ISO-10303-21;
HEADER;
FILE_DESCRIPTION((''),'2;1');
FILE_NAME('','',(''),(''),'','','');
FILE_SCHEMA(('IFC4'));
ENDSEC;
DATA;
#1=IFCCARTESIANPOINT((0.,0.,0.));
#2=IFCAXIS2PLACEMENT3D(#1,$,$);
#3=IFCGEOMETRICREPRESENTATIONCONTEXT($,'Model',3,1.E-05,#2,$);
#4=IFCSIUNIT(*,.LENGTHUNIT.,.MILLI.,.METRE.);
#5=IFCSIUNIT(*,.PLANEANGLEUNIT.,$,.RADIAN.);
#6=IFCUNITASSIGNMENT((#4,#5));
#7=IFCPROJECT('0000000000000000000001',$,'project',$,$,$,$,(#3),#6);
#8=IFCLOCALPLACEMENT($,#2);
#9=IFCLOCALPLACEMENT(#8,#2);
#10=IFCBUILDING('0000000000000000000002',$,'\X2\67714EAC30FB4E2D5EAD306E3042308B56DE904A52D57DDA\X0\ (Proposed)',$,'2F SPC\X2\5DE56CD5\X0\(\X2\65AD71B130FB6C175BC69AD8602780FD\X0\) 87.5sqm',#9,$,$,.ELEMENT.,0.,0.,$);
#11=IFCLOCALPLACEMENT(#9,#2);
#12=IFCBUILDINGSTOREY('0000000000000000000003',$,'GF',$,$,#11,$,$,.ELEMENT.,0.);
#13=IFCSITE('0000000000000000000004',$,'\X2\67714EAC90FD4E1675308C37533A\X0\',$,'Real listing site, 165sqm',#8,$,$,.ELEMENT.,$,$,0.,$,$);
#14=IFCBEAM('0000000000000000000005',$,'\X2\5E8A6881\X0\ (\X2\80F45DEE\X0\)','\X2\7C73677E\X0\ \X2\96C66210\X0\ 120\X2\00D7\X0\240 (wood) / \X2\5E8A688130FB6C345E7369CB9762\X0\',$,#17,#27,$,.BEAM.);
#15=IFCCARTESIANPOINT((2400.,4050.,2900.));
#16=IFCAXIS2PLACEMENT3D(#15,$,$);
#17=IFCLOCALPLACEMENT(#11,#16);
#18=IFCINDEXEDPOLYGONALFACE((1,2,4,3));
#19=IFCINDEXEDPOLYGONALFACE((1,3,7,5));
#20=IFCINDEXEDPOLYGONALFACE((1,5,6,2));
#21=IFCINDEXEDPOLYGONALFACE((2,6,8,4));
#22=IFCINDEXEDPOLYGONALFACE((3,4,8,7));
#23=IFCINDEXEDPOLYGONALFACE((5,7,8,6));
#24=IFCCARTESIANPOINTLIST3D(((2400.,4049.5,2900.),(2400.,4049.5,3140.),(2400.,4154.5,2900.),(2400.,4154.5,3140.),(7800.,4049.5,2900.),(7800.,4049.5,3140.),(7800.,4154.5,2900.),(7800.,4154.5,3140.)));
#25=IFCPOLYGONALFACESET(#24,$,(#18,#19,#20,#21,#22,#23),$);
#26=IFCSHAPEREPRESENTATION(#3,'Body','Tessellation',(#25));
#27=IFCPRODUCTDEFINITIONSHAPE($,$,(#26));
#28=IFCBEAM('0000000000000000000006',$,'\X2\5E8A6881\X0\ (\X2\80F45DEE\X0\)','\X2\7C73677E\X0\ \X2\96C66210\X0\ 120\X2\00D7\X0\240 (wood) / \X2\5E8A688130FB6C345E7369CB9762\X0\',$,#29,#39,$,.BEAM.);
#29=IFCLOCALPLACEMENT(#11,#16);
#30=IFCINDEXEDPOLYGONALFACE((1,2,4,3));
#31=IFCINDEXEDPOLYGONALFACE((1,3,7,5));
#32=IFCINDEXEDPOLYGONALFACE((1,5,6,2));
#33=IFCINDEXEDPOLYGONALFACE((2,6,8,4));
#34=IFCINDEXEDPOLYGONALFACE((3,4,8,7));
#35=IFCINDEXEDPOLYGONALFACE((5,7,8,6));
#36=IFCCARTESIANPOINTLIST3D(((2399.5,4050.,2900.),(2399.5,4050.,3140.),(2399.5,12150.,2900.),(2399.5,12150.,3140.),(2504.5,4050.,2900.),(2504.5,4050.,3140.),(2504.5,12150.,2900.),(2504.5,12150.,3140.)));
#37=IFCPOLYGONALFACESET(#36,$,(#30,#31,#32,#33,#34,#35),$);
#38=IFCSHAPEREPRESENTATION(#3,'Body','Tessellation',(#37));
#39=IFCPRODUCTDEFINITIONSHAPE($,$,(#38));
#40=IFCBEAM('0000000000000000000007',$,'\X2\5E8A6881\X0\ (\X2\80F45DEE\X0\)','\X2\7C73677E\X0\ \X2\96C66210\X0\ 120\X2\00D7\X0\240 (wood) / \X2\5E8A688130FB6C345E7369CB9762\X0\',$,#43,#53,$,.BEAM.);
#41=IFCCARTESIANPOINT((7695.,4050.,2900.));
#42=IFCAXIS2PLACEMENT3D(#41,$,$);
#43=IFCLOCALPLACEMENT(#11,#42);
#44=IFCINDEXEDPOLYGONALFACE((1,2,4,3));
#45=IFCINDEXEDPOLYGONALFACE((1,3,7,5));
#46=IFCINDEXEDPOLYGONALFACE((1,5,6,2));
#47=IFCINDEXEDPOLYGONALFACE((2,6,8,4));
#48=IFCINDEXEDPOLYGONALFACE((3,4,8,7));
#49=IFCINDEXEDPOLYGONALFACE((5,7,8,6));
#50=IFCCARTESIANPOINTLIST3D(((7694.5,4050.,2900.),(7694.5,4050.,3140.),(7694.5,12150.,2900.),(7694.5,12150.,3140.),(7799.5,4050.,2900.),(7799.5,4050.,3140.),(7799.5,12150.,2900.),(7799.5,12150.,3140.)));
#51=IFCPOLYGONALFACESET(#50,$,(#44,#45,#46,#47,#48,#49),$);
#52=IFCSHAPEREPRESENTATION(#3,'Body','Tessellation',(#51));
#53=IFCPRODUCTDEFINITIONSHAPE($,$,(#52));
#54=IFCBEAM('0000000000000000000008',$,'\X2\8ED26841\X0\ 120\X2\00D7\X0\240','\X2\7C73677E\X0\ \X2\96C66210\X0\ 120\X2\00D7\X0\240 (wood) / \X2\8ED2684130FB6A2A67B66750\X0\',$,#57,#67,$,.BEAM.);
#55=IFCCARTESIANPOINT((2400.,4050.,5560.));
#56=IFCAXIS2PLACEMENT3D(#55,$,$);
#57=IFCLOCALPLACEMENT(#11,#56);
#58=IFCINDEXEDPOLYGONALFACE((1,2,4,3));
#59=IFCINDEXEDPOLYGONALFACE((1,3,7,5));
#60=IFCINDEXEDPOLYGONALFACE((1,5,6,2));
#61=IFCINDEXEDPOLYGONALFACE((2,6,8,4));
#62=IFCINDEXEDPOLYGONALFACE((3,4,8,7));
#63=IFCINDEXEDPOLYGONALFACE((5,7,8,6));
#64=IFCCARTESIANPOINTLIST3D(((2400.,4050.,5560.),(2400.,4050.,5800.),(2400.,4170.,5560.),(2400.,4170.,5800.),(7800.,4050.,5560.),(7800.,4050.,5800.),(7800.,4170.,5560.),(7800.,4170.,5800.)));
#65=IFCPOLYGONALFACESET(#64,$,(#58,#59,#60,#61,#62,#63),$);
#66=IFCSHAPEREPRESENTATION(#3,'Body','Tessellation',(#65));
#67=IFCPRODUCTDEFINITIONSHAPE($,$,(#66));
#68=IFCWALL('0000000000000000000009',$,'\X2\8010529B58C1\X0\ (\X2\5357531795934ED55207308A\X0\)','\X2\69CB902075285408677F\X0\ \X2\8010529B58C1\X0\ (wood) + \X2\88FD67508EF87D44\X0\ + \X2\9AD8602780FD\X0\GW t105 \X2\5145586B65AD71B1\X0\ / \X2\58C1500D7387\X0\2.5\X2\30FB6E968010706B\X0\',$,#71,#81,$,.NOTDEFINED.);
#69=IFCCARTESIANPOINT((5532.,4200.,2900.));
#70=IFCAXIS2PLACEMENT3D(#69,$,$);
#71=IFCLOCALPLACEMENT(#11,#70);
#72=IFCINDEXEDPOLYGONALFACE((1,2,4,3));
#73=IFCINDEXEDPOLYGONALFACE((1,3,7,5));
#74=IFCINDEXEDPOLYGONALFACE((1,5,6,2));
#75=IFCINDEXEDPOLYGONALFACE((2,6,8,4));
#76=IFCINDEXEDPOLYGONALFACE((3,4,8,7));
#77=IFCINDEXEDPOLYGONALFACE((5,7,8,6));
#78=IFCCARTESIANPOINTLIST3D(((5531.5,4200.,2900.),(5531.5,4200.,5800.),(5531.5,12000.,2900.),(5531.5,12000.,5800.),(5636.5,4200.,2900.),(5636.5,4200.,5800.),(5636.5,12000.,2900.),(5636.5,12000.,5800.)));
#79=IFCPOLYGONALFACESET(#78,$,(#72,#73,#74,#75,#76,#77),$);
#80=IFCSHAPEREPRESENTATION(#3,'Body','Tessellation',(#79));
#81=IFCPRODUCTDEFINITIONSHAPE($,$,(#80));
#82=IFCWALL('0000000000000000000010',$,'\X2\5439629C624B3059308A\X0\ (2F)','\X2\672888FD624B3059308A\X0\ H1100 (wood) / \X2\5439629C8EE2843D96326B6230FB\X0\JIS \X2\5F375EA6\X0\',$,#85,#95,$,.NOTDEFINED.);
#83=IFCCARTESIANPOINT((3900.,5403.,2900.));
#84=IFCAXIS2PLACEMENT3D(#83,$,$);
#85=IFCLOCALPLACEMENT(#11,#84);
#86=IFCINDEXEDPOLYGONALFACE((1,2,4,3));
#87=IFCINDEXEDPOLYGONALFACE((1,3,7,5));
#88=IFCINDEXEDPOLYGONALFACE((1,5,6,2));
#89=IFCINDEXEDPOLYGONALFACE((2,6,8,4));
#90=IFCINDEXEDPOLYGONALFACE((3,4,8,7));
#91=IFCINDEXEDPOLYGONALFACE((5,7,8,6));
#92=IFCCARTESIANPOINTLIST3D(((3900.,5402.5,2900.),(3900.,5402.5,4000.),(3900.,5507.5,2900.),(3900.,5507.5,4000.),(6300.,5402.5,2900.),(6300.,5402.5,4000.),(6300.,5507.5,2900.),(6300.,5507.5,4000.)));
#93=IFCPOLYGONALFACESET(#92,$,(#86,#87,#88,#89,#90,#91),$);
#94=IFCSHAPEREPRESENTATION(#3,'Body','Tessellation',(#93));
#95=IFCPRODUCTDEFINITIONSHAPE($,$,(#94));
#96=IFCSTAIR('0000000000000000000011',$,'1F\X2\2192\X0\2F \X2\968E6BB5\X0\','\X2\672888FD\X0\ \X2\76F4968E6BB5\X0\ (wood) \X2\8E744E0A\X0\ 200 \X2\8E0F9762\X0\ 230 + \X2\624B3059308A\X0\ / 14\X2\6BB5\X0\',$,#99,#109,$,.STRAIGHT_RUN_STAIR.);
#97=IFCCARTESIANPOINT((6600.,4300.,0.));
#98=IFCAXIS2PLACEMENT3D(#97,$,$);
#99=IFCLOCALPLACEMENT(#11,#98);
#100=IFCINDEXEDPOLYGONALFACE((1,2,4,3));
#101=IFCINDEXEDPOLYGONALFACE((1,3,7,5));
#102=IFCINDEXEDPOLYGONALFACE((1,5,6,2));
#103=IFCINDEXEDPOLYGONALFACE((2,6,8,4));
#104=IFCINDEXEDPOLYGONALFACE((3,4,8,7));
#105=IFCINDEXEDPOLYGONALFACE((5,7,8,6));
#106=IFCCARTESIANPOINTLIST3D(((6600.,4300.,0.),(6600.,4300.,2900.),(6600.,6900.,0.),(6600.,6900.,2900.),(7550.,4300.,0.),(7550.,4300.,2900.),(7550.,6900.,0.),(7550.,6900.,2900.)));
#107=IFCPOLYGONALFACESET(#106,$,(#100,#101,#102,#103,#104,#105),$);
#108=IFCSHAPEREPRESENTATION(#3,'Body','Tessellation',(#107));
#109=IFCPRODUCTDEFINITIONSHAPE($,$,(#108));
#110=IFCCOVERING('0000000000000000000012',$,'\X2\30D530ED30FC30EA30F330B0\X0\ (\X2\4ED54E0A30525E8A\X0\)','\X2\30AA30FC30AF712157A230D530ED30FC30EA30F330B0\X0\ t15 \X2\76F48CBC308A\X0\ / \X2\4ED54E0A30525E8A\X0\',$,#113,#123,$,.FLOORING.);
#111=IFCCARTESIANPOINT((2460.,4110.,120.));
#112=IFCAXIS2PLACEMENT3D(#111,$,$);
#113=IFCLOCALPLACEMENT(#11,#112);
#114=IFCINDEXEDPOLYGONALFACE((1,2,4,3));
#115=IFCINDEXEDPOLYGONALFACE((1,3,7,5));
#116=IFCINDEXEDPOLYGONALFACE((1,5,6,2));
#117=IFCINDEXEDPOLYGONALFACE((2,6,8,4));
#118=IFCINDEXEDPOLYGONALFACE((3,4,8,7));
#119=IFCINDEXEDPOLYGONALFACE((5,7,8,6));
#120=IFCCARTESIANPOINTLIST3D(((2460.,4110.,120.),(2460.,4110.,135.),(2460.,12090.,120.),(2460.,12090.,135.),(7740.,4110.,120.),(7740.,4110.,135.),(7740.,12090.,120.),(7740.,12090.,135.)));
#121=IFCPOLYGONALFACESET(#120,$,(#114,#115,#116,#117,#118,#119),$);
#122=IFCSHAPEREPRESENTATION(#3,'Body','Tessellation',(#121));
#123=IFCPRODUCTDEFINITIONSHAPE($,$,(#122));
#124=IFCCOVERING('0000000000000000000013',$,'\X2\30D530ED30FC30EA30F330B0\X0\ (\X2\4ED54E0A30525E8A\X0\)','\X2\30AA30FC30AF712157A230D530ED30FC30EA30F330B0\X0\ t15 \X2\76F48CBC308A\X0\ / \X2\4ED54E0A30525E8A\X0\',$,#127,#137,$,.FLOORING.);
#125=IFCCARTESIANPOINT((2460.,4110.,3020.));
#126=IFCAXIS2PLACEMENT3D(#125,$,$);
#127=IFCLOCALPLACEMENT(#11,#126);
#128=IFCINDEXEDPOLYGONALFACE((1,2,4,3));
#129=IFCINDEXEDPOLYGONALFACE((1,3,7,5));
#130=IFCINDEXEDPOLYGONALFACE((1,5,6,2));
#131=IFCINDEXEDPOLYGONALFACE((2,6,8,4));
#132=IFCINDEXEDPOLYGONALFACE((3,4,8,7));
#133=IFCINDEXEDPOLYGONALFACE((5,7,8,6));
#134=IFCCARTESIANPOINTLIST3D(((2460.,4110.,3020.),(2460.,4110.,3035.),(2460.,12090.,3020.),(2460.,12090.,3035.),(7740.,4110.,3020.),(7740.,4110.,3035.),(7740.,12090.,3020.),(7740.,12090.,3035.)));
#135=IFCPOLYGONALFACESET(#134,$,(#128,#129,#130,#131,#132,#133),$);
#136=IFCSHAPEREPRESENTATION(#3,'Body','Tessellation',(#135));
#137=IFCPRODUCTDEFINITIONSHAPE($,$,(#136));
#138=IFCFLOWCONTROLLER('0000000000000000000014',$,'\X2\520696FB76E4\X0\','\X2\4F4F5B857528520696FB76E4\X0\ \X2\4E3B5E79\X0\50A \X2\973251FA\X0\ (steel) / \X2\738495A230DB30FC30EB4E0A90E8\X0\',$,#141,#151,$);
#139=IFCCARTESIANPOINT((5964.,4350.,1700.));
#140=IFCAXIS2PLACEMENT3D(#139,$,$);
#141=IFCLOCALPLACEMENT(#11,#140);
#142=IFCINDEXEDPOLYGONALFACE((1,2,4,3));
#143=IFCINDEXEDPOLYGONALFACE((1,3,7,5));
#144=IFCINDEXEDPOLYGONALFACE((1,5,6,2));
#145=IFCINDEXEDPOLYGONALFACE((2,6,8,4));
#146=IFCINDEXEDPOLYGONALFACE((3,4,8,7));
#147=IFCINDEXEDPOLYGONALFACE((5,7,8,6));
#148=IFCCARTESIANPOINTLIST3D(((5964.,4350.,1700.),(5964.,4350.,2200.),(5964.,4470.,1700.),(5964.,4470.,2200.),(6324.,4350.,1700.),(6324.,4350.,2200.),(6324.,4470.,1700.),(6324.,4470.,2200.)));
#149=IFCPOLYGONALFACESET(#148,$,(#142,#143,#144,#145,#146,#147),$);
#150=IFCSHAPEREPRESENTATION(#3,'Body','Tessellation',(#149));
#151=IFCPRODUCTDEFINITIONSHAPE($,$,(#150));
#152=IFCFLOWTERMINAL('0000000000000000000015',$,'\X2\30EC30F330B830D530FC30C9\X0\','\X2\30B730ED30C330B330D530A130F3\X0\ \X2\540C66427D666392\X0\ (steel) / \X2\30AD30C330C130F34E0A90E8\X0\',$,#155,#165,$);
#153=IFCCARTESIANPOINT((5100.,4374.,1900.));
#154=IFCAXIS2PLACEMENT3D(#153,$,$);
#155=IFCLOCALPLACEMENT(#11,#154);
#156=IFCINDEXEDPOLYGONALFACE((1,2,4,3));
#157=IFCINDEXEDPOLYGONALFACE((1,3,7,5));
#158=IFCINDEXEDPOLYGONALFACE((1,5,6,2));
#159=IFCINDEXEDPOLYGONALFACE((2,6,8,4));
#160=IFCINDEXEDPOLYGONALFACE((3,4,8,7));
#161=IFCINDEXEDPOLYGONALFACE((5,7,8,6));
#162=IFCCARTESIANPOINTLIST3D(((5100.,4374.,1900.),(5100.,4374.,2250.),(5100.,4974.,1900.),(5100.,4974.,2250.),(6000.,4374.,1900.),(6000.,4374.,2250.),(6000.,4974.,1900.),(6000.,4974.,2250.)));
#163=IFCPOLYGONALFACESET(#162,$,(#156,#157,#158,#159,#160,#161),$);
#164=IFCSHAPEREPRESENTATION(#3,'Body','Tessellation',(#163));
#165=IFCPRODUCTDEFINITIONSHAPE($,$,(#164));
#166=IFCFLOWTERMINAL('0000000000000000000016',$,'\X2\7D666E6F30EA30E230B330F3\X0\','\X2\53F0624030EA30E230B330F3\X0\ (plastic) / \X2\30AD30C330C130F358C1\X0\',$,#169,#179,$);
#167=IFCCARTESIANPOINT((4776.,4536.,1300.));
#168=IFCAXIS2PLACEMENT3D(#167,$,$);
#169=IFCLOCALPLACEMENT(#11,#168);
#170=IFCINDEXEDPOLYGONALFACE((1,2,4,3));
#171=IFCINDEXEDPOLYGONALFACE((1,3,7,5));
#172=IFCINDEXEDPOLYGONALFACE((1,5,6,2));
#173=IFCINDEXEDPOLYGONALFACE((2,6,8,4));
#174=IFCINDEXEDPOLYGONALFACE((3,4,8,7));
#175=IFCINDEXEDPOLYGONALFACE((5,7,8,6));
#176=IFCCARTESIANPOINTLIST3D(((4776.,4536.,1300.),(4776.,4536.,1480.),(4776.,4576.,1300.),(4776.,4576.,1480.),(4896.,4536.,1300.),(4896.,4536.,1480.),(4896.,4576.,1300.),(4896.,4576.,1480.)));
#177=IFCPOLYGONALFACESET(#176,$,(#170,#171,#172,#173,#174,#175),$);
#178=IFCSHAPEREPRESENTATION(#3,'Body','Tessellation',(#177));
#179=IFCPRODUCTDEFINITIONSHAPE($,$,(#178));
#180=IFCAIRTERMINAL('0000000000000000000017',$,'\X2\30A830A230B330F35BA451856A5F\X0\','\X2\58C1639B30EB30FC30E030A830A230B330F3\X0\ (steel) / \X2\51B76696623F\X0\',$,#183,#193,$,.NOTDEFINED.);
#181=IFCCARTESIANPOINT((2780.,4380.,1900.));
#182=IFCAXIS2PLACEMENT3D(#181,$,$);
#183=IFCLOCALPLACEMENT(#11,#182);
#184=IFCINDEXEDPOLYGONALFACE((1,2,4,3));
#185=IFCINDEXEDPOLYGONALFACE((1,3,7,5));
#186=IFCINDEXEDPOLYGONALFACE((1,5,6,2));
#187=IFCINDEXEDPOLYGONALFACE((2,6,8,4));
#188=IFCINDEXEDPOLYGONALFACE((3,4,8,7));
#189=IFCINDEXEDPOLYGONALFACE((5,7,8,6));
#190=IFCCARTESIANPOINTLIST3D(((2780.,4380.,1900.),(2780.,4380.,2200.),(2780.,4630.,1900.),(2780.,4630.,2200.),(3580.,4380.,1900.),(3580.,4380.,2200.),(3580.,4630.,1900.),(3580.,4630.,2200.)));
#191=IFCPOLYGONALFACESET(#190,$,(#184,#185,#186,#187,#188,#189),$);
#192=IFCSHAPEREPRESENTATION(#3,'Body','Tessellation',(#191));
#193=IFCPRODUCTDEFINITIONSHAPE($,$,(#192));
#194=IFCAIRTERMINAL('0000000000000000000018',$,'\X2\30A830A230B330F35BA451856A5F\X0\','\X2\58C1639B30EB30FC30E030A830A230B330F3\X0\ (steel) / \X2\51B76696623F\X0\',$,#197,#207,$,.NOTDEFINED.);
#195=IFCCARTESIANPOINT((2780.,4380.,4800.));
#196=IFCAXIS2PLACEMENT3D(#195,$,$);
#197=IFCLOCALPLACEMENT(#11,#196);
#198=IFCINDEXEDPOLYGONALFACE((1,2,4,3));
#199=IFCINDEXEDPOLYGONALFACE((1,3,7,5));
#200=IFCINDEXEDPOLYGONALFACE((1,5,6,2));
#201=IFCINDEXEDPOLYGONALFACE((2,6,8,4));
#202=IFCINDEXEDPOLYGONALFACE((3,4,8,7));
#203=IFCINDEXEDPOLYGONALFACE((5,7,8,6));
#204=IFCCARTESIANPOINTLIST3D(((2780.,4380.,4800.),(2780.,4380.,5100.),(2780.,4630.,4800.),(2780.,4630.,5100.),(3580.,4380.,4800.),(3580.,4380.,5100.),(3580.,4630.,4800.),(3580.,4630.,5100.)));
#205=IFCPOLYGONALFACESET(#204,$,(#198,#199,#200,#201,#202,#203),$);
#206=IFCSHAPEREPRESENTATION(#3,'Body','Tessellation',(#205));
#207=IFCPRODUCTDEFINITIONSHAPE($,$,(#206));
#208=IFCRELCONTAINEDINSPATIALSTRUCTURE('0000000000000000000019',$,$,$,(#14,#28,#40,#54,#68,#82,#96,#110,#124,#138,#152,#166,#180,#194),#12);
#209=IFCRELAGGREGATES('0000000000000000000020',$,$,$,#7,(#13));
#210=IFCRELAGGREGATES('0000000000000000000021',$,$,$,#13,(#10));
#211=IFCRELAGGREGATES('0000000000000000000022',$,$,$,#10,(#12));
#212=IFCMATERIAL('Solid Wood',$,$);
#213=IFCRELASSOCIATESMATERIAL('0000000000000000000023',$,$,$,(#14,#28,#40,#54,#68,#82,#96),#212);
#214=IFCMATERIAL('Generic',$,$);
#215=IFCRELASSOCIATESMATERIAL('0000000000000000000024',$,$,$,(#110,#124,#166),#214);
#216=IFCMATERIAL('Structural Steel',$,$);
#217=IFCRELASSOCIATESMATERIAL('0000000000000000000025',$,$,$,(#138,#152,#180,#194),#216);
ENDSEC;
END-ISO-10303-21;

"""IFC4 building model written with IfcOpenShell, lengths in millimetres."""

from ifc_helpers import new_model, si_unit, frame, frame_2d, origin, place, context, project, spatial, rectangle, extrude, material, element, save


model = new_model("IFC4")

# Units and contexts
model_context = context("Model", 3, precision=1e-05, world=origin())
ifc_project = project(units=[si_unit("LENGTHUNIT", "METRE", prefix="MILLI"), si_unit("PLANEANGLEUNIT", "RADIAN")], contexts=[model_context])

# Site, building, storey
site_placement = place(None, origin())
site = spatial("IfcSite", under=ifc_project, at=site_placement, Name="東京都世田谷区", ObjectType="Real listing site, 165sqm", CompositionType="ELEMENT", RefElevation=0.0)
building_placement = place(site_placement, origin())
building = spatial("IfcBuilding", under=site, at=building_placement, Name="東京・中庭のある回遊動線 (Proposed)", ObjectType="2F SPC工法(断熱・気密高性能) 87.5sqm", CompositionType="ELEMENT", ElevationOfRefHeight=0.0, ElevationOfTerrain=0.0)
storey_placement = place(building_placement, origin())
storey = spatial("IfcBuildingStorey", under=building, at=storey_placement, Name="GF", CompositionType="ELEMENT", Elevation=0.0)

# Shared definitions
ifc_material_1 = material(Name="Solid Wood")

# Beams
beam_1_placement = place(storey_placement, frame((2400.0, 4050.0, 2900.0)))
element("IfcBeam", 1, at=beam_1_placement, inside=storey, material=ifc_material_1, Name="床梁 (胴差)", Description="米松 集成 120×240 (wood) / 床梁・水平構面", PredefinedType="BEAM", context=model_context, shape_type="SweptSolid", body=[
    extrude(rectangle(XDim=5400.0, YDim=105.0, at=frame_2d((2700.0, 52.0))), frame((2400.0, 4050.0, 2900.0)), (0.0, 0.0, 1.0), 240.0),
])
beam_2_placement = place(storey_placement, frame((2400.0, 4050.0, 2900.0)))
element("IfcBeam", 2, at=beam_2_placement, inside=storey, material=ifc_material_1, Name="床梁 (胴差)", Description="米松 集成 120×240 (wood) / 床梁・水平構面", PredefinedType="BEAM", context=model_context, shape_type="SweptSolid", body=[
    extrude(rectangle(XDim=105.0, YDim=8100.0, at=frame_2d((52.0, 4050.0))), frame((2400.0, 4050.0, 2900.0)), (0.0, 0.0, 1.0), 240.0),
])
beam_3_placement = place(storey_placement, frame((7695.0, 4050.0, 2900.0)))
element("IfcBeam", 3, at=beam_3_placement, inside=storey, material=ifc_material_1, Name="床梁 (胴差)", Description="米松 集成 120×240 (wood) / 床梁・水平構面", PredefinedType="BEAM", context=model_context, shape_type="SweptSolid", body=[
    extrude(rectangle(XDim=105.0, YDim=8100.0, at=frame_2d((52.0, 4050.0))), frame((7695.0, 4050.0, 2900.0)), (0.0, 0.0, 1.0), 240.0),
])
beam_4_placement = place(storey_placement, frame((2400.0, 4050.0, 5560.0)))
element("IfcBeam", 4, at=beam_4_placement, inside=storey, material=ifc_material_1, Name="軒桁 120×240", Description="米松 集成 120×240 (wood) / 軒桁・横架材", PredefinedType="BEAM", context=model_context, shape_type="SweptSolid", body=[
    extrude(rectangle(XDim=5400.0, YDim=120.0, at=frame_2d((2700.0, 60.0))), frame((2400.0, 4050.0, 5560.0)), (0.0, 0.0, 1.0), 240.0),
])

# Walls
wall_1_placement = place(storey_placement, frame((5532.0, 4200.0, 2900.0)))
element("IfcWall", 5, at=wall_1_placement, inside=storey, material=ifc_material_1, Name="耐力壁 (南北間仕切り)", Description="構造用合板 耐力壁 (wood) + 製材軸組 + 高性能GW t105 充填断熱 / 壁倍率2.5・準耐火", PredefinedType="NOTDEFINED", context=model_context, shape_type="SweptSolid", body=[
    extrude(rectangle(XDim=105.0, YDim=7800.0, at=frame_2d((52.0, 3900.0))), frame((5532.0, 4200.0, 2900.0)), (0.0, 0.0, 1.0), 2900.0),
])
wall_2_placement = place(storey_placement, frame((3900.0, 5403.0, 2900.0)))
element("IfcWall", 6, at=wall_2_placement, inside=storey, material=ifc_material_1, Name="吹抜手すり (2F)", Description="木製手すり H1100 (wood) / 吹抜転落防止・JIS 強度", PredefinedType="NOTDEFINED", context=model_context, shape_type="SweptSolid", body=[
    extrude(rectangle(XDim=2400.0, YDim=105.0, at=frame_2d((1200.0, 52.0))), frame((3900.0, 5403.0, 2900.0)), (0.0, 0.0, 1.0), 1100.0),
])

# Stair
stair_placement = place(storey_placement, frame((6600.0, 4300.0, 0.0)))
element("IfcStair", 7, at=stair_placement, inside=storey, material=ifc_material_1, Name="1F→2F 階段", Description="木製 直階段 (wood) 蹴上 200 踏面 230 + 手すり / 14段", PredefinedType="STRAIGHT_RUN_STAIR", context=model_context, shape_type="SweptSolid", body=[
    extrude(rectangle(XDim=950.0, YDim=2600.0, at=frame_2d((475.0, 1300.0))), frame((6600.0, 4300.0, 0.0)), (0.0, 0.0, 1.0), 2900.0),
])

# Coverings
ifc_material_2 = material(Name="Generic")
covering_1_placement = place(storey_placement, frame((2460.0, 4110.0, 120.0)))
element("IfcCovering", 8, at=covering_1_placement, inside=storey, material=ifc_material_2, Name="フローリング (仕上げ床)", Description="オーク無垢フローリング t15 直貼り / 仕上げ床", PredefinedType="FLOORING", context=model_context, shape_type="SweptSolid", body=[
    extrude(rectangle(XDim=5280.0, YDim=7980.0, at=frame_2d((2640.0, 3990.0))), frame((2460.0, 4110.0, 120.0)), (0.0, 0.0, 1.0), 15.0),
])
covering_2_placement = place(storey_placement, frame((2460.0, 4110.0, 3020.0)))
element("IfcCovering", 9, at=covering_2_placement, inside=storey, material=ifc_material_2, Name="フローリング (仕上げ床)", Description="オーク無垢フローリング t15 直貼り / 仕上げ床", PredefinedType="FLOORING", context=model_context, shape_type="SweptSolid", body=[
    extrude(rectangle(XDim=5280.0, YDim=7980.0, at=frame_2d((2640.0, 3990.0))), frame((2460.0, 4110.0, 3020.0)), (0.0, 0.0, 1.0), 15.0),
])

# Flow controller
ifc_material_3 = material(Name="Structural Steel")
flow_controller_placement = place(storey_placement, frame((5964.0, 4350.0, 1700.0)))
element("IfcFlowController", 10, at=flow_controller_placement, inside=storey, material=ifc_material_3, Name="分電盤", Description="住宅用分電盤 主幹50A 露出 (steel) / 玄関ホール上部", context=model_context, shape_type="SweptSolid", body=[
    extrude(rectangle(XDim=360.0, YDim=120.0, at=frame_2d((180.0, 60.0))), frame((5964.0, 4350.0, 1700.0)), (0.0, 0.0, 1.0), 500.0),
])

# Flow terminals
flow_terminal_1_placement = place(storey_placement, frame((5100.0, 4374.0, 1900.0)))
element("IfcFlowTerminal", 11, at=flow_terminal_1_placement, inside=storey, material=ifc_material_3, Name="レンジフード", Description="シロッコファン 同時給排 (steel) / キッチン上部", context=model_context, shape_type="SweptSolid", body=[
    extrude(rectangle(XDim=900.0, YDim=600.0, at=frame_2d((450.0, 300.0))), frame((5100.0, 4374.0, 1900.0)), (0.0, 0.0, 1.0), 350.0),
])
flow_terminal_2_placement = place(storey_placement, frame((4776.0, 4536.0, 1300.0)))
element("IfcFlowTerminal", 12, at=flow_terminal_2_placement, inside=storey, material=ifc_material_2, Name="給湯リモコン", Description="台所リモコン (plastic) / キッチン壁", context=model_context, shape_type="SweptSolid", body=[
    extrude(rectangle(XDim=120.0, YDim=40.0, at=frame_2d((60.0, 20.0))), frame((4776.0, 4536.0, 1300.0)), (0.0, 0.0, 1.0), 180.0),
])

# Air terminals
air_terminal_1_placement = place(storey_placement, frame((2780.0, 4380.0, 1900.0)))
element("IfcAirTerminal", 13, at=air_terminal_1_placement, inside=storey, material=ifc_material_3, Name="エアコン室内機", Description="壁掛ルームエアコン (steel) / 冷暖房", PredefinedType="NOTDEFINED", context=model_context, shape_type="SweptSolid", body=[
    extrude(rectangle(XDim=800.0, YDim=250.0, at=frame_2d((400.0, 125.0))), frame((2780.0, 4380.0, 1900.0)), (0.0, 0.0, 1.0), 300.0),
])
air_terminal_2_placement = place(storey_placement, frame((2780.0, 4380.0, 4800.0)))
element("IfcAirTerminal", 14, at=air_terminal_2_placement, inside=storey, material=ifc_material_3, Name="エアコン室内機", Description="壁掛ルームエアコン (steel) / 冷暖房", PredefinedType="NOTDEFINED", context=model_context, shape_type="SweptSolid", body=[
    extrude(rectangle(XDim=800.0, YDim=250.0, at=frame_2d((400.0, 125.0))), frame((2780.0, 4380.0, 4800.0)), (0.0, 0.0, 1.0), 300.0),
])

save(model, "model.ifc")
